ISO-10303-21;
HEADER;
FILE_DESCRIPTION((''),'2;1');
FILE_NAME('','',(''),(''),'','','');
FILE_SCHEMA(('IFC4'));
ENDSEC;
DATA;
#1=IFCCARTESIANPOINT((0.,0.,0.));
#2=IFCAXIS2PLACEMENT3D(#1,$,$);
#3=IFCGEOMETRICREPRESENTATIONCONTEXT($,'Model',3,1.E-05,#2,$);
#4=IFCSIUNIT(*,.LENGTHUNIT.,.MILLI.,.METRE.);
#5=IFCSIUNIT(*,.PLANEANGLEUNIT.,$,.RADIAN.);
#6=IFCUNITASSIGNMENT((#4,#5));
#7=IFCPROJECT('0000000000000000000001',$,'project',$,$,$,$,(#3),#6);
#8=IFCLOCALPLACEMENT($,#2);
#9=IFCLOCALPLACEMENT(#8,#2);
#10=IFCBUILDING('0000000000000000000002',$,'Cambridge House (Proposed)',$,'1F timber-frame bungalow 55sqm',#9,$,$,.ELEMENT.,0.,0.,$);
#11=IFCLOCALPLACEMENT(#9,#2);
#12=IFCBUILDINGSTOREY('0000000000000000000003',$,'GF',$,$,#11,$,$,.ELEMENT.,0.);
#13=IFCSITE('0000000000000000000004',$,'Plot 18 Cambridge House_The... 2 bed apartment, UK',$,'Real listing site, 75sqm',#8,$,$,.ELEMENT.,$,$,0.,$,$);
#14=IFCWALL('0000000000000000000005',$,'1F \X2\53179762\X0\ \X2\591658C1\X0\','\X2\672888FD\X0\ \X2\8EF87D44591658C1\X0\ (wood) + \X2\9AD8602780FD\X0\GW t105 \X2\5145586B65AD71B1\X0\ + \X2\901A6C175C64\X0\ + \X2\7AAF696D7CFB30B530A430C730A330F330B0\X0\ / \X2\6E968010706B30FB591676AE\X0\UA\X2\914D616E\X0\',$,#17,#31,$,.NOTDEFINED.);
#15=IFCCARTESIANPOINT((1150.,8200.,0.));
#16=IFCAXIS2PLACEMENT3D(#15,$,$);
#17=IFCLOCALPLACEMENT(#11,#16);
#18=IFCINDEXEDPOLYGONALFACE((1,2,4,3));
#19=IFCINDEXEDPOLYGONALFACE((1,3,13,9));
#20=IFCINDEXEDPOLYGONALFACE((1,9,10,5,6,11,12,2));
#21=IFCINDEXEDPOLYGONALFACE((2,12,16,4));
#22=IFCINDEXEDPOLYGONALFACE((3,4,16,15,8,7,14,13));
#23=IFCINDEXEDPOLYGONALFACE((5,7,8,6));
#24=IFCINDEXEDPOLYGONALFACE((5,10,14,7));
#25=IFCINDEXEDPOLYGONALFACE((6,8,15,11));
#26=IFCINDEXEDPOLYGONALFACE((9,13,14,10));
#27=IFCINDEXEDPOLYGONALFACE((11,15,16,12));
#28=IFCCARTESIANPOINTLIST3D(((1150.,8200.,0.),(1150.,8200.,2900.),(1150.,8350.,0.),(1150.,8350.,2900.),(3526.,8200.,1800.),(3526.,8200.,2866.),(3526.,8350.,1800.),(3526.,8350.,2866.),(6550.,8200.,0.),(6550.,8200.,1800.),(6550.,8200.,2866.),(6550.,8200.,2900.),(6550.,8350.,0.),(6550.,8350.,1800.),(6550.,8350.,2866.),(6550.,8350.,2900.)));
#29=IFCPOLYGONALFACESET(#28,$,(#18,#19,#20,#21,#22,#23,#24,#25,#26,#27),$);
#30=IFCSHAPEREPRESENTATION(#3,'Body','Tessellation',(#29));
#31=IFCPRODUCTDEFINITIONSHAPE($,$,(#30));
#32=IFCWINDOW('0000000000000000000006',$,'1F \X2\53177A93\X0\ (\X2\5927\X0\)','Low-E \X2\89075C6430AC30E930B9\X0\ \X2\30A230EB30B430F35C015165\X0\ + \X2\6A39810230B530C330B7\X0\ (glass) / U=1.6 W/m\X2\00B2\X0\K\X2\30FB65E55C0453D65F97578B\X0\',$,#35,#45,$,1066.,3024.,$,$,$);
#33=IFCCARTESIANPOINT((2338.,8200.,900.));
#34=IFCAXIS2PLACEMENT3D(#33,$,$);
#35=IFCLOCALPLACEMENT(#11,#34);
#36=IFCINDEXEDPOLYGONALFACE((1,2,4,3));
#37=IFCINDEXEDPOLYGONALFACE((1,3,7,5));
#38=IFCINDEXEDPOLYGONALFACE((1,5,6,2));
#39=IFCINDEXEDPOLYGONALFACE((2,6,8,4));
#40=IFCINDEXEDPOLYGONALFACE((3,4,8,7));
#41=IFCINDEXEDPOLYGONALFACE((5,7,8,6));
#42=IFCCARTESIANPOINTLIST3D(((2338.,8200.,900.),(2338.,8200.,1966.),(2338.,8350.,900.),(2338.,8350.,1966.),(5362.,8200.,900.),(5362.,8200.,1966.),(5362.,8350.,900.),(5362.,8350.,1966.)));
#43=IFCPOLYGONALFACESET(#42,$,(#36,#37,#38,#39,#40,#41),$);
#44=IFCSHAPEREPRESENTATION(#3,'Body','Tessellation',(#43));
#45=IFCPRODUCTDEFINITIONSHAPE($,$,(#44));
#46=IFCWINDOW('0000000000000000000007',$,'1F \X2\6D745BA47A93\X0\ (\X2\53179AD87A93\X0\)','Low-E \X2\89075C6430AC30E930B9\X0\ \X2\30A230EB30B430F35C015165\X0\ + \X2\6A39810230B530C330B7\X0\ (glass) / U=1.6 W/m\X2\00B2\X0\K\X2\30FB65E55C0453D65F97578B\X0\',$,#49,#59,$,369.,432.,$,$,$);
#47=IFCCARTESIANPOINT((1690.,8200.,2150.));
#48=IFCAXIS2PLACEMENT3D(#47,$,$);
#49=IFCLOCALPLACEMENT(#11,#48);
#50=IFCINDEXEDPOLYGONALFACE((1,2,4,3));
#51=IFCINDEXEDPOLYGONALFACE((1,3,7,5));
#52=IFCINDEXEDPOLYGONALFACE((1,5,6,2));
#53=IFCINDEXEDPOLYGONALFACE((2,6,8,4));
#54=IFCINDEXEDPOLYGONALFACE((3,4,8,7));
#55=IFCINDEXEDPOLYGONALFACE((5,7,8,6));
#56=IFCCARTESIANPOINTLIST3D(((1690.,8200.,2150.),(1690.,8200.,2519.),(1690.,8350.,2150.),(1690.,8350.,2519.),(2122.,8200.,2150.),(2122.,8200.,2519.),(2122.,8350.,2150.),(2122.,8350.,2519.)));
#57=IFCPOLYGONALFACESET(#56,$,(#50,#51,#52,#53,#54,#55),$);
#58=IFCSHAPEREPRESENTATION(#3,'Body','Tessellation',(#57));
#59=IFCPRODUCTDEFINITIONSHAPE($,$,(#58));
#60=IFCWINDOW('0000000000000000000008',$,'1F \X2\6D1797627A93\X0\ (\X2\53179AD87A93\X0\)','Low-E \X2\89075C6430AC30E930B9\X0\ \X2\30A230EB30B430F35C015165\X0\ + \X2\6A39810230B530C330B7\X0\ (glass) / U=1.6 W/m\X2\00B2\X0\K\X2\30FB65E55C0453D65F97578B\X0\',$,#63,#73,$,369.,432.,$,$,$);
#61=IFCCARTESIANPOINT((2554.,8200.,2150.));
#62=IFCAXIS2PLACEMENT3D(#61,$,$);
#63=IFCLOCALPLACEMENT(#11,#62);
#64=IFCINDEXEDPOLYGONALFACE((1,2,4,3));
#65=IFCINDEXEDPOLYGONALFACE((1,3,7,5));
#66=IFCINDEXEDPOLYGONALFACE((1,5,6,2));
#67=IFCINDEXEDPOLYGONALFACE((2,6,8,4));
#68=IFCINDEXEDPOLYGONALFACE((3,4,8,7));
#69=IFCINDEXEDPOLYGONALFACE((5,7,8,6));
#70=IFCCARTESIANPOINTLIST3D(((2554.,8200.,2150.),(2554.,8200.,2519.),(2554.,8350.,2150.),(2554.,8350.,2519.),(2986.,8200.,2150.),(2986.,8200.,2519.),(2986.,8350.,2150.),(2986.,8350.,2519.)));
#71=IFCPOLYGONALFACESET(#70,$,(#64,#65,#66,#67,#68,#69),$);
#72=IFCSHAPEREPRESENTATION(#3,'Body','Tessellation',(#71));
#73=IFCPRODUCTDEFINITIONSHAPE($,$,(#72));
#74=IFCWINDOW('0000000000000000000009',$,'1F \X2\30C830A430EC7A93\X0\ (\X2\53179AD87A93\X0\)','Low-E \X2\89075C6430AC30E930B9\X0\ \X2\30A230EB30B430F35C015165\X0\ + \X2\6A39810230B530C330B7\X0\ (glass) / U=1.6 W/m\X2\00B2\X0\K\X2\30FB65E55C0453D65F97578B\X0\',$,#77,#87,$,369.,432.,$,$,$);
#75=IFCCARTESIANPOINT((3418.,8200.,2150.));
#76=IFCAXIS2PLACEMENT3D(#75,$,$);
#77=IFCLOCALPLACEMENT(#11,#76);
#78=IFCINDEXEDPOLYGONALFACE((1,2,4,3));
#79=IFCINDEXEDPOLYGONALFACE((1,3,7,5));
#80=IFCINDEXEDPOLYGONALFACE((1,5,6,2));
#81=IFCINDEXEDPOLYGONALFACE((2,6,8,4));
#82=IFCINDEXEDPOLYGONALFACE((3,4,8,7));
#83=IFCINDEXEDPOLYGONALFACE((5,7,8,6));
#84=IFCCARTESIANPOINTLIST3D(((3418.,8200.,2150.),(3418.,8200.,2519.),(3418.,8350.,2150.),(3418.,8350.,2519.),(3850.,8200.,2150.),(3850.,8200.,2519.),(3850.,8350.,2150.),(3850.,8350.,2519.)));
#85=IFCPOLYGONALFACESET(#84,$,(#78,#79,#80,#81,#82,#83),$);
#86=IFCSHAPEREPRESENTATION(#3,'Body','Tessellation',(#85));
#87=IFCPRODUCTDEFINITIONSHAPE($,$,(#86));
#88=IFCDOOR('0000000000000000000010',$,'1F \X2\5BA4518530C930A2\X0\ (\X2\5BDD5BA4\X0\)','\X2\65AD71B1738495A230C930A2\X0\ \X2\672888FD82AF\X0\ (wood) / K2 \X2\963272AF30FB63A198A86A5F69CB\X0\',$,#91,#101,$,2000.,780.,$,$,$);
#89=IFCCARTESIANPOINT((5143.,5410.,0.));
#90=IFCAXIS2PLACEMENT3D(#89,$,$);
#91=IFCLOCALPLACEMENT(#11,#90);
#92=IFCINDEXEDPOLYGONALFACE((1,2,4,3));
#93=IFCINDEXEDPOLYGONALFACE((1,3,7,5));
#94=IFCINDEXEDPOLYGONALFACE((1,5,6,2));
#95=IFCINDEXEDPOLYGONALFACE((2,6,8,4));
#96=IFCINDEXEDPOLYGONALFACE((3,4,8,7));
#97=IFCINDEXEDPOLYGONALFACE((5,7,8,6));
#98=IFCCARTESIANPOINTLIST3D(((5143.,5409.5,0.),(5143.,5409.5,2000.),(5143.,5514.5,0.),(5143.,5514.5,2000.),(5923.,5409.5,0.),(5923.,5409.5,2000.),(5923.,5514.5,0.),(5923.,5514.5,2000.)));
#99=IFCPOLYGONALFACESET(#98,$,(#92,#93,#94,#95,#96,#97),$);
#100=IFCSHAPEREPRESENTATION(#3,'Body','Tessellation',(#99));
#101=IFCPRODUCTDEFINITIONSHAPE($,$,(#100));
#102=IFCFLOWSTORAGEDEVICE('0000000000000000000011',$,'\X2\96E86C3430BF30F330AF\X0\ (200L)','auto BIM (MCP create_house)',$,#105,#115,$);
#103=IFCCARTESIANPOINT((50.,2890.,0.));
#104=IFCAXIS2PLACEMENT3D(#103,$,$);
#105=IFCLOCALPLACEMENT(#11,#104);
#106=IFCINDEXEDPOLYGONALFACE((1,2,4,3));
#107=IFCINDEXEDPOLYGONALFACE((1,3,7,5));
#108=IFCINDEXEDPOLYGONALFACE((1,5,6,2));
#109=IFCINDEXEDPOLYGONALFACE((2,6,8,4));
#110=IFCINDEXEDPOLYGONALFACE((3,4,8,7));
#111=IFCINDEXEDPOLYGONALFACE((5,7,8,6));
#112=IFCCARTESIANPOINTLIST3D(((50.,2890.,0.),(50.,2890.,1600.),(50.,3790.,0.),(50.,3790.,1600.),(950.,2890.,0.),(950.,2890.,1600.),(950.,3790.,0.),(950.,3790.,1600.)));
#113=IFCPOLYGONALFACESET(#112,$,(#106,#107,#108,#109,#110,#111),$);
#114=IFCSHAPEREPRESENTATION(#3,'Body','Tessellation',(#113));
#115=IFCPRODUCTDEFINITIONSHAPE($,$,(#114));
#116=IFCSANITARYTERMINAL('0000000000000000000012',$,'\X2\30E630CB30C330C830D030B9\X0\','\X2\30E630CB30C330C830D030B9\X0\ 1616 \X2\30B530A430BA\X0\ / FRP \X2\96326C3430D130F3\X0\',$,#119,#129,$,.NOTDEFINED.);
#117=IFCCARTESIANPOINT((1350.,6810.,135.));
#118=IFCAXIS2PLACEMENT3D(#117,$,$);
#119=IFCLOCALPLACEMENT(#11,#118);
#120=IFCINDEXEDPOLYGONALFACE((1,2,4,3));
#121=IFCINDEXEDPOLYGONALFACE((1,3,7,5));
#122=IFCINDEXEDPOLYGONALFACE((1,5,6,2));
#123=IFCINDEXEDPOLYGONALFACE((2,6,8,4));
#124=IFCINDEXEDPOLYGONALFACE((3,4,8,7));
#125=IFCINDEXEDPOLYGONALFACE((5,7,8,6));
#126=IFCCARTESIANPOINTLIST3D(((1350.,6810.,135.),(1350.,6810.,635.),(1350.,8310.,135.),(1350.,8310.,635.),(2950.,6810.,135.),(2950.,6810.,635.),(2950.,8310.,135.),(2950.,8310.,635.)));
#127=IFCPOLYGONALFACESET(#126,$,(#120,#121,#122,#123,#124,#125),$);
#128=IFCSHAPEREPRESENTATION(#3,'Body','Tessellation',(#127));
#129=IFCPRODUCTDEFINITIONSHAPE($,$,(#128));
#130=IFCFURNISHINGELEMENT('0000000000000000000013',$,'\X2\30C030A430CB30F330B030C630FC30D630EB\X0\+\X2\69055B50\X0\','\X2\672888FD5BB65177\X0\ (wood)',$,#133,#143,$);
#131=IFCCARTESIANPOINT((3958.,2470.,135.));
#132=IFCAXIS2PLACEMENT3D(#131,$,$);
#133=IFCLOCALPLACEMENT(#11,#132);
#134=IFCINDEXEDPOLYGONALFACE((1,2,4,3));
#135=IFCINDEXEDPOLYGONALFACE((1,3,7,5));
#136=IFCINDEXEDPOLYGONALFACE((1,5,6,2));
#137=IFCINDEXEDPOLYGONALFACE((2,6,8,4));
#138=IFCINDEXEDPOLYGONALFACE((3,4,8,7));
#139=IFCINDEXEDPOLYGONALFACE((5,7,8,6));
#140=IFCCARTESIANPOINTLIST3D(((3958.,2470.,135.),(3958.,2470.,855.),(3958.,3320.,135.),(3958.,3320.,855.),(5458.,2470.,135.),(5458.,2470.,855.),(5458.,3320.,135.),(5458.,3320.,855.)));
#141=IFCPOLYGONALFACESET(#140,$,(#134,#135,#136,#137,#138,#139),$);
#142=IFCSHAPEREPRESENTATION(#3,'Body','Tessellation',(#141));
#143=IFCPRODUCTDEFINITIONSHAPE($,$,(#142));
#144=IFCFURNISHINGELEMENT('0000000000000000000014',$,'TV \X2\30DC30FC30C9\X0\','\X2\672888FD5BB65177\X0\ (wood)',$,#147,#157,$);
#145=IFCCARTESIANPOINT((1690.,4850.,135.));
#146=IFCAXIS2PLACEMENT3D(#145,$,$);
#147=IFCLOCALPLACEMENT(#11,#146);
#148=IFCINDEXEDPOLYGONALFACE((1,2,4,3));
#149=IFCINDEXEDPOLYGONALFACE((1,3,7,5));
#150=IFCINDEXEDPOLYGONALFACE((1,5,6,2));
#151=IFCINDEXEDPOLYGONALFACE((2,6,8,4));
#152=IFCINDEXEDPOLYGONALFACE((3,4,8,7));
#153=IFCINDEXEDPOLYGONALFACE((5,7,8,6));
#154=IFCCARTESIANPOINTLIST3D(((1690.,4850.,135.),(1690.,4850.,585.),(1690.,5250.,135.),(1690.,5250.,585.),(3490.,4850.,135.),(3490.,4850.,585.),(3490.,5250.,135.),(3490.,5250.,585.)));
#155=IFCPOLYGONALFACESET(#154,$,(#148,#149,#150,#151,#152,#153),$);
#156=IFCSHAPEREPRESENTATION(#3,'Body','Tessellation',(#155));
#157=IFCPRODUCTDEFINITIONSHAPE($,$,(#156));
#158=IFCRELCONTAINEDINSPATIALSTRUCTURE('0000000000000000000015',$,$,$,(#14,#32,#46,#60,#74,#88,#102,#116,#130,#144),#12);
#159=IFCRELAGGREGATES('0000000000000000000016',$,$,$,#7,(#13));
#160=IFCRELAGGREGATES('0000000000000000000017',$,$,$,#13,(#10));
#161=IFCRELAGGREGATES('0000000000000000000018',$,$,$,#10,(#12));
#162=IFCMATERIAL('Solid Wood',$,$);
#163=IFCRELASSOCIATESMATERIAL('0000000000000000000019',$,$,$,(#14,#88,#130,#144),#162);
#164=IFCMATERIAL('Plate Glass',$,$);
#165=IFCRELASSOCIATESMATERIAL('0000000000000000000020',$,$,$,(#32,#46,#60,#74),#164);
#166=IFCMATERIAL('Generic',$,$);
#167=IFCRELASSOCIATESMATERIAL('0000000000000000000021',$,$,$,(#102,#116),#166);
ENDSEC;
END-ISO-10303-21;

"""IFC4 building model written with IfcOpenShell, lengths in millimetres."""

from ifc_helpers import new_model, si_unit, frame, frame_2d, origin, place, context, project, spatial, rectangle, extrude, material, element, fill, save


model = new_model("IFC4")

# Units and contexts
model_context = context("Model", 3, precision=1e-05, world=origin())
ifc_project = project(units=[si_unit("LENGTHUNIT", "METRE", prefix="MILLI"), si_unit("PLANEANGLEUNIT", "RADIAN")], contexts=[model_context])

# Site, building, storey
site_placement = place(None, origin())
site = spatial("IfcSite", under=ifc_project, at=site_placement, Name="Plot 18 Cambridge House_The... 2 bed apartment, UK", ObjectType="Real listing site, 75sqm", CompositionType="ELEMENT", RefElevation=0.0)
building_placement = place(site_placement, origin())
building = spatial("IfcBuilding", under=site, at=building_placement, Name="Cambridge House (Proposed)", ObjectType="1F timber-frame bungalow 55sqm", CompositionType="ELEMENT", ElevationOfRefHeight=0.0, ElevationOfTerrain=0.0)
storey_placement = place(building_placement, origin())
storey = spatial("IfcBuildingStorey", under=building, at=storey_placement, Name="GF", CompositionType="ELEMENT", Elevation=0.0)

# Wall, openings, windows
ifc_material_1 = material(Name="Solid Wood")
wall_1_placement = place(storey_placement, frame((1150.0, 8200.0, 0.0)))
wall_1 = element("IfcWall", 1, at=wall_1_placement, inside=storey, material=ifc_material_1, Name="1F 北面 外壁", Description="木製 軸組外壁 (wood) + 高性能GW t105 充填断熱 + 通気層 + 窯業系サイディング / 準耐火・外皮UA配慮", PredefinedType="NOTDEFINED", context=model_context, shape_type="SweptSolid", body=[
    extrude(rectangle(XDim=5400.0, YDim=150.0, at=frame_2d((2700.0, 75.0))), frame((1150.0, 8200.0, 0.0)), (0.0, 0.0, 1.0), 2900.0),
])
opening_1_placement = place(storey_placement, frame((2338.0, 8200.0, 900.0)))
opening_1 = element("IfcOpeningElement", 2, at=opening_1_placement, cuts=wall_1, PredefinedType="NOTDEFINED", context=model_context, shape_type="SweptSolid", body=[
    extrude(rectangle(XDim=3024.0, YDim=150.0, at=frame_2d((1512.0, 75.0))), frame((2338.0, 8200.0, 900.0)), (0.0, 0.0, 1.0), 1066.0),
])
opening_2_placement = place(storey_placement, frame((1690.0, 8200.0, 2150.0)))
opening_2 = element("IfcOpeningElement", 3, at=opening_2_placement, cuts=wall_1, PredefinedType="NOTDEFINED", context=model_context, shape_type="SweptSolid", body=[
    extrude(rectangle(XDim=432.0, YDim=150.0, at=frame_2d((216.0, 75.0))), frame((1690.0, 8200.0, 2150.0)), (0.0, 0.0, 1.0), 369.0),
])
opening_3_placement = place(storey_placement, frame((2554.0, 8200.0, 2150.0)))
opening_3 = element("IfcOpeningElement", 4, at=opening_3_placement, cuts=wall_1, PredefinedType="NOTDEFINED", context=model_context, shape_type="SweptSolid", body=[
    extrude(rectangle(XDim=432.0, YDim=150.0, at=frame_2d((216.0, 75.0))), frame((2554.0, 8200.0, 2150.0)), (0.0, 0.0, 1.0), 369.0),
])
opening_4_placement = place(storey_placement, frame((3418.0, 8200.0, 2150.0)))
opening_4 = element("IfcOpeningElement", 5, at=opening_4_placement, cuts=wall_1, PredefinedType="NOTDEFINED", context=model_context, shape_type="SweptSolid", body=[
    extrude(rectangle(XDim=432.0, YDim=150.0, at=frame_2d((216.0, 75.0))), frame((3418.0, 8200.0, 2150.0)), (0.0, 0.0, 1.0), 369.0),
])
ifc_material_2 = material(Name="Plate Glass")
window_1_placement = place(storey_placement, frame((2338.0, 8200.0, 900.0)))
window_1 = element("IfcWindow", 6, at=window_1_placement, inside=storey, material=ifc_material_2, Name="1F 北窓 (大)", Description="Low-E 複層ガラス アルゴン封入 + 樹脂サッシ (glass) / U=1.6 W/m²K・日射取得型", OverallHeight=1066.0, OverallWidth=3024.0, context=model_context, shape_type="SweptSolid", body=[
    extrude(rectangle(XDim=3024.0, YDim=150.0, at=frame_2d((1512.0, 75.0))), frame((2338.0, 8200.0, 900.0)), (0.0, 0.0, 1.0), 1066.0),
])
fill(opening_1, window_1)
window_2_placement = place(storey_placement, frame((1690.0, 8200.0, 2150.0)))
window_2 = element("IfcWindow", 7, at=window_2_placement, inside=storey, material=ifc_material_2, Name="1F 浴室窓 (北高窓)", Description="Low-E 複層ガラス アルゴン封入 + 樹脂サッシ (glass) / U=1.6 W/m²K・日射取得型", OverallHeight=369.0, OverallWidth=432.0, context=model_context, shape_type="SweptSolid", body=[
    extrude(rectangle(XDim=432.0, YDim=150.0, at=frame_2d((216.0, 75.0))), frame((1690.0, 8200.0, 2150.0)), (0.0, 0.0, 1.0), 369.0),
])
fill(opening_2, window_2)
window_3_placement = place(storey_placement, frame((2554.0, 8200.0, 2150.0)))
window_3 = element("IfcWindow", 8, at=window_3_placement, inside=storey, material=ifc_material_2, Name="1F 洗面窓 (北高窓)", Description="Low-E 複層ガラス アルゴン封入 + 樹脂サッシ (glass) / U=1.6 W/m²K・日射取得型", OverallHeight=369.0, OverallWidth=432.0, context=model_context, shape_type="SweptSolid", body=[
    extrude(rectangle(XDim=432.0, YDim=150.0, at=frame_2d((216.0, 75.0))), frame((2554.0, 8200.0, 2150.0)), (0.0, 0.0, 1.0), 369.0),
])
fill(opening_3, window_3)
window_4_placement = place(storey_placement, frame((3418.0, 8200.0, 2150.0)))
window_4 = element("IfcWindow", 9, at=window_4_placement, inside=storey, material=ifc_material_2, Name="1F トイレ窓 (北高窓)", Description="Low-E 複層ガラス アルゴン封入 + 樹脂サッシ (glass) / U=1.6 W/m²K・日射取得型", OverallHeight=369.0, OverallWidth=432.0, context=model_context, shape_type="SweptSolid", body=[
    extrude(rectangle(XDim=432.0, YDim=150.0, at=frame_2d((216.0, 75.0))), frame((3418.0, 8200.0, 2150.0)), (0.0, 0.0, 1.0), 369.0),
])
fill(opening_4, window_4)

# Door
door_1_placement = place(storey_placement, frame((5143.0, 5410.0, 0.0)))
element("IfcDoor", 10, at=door_1_placement, inside=storey, material=ifc_material_1, Name="1F 室内ドア (寝室)", Description="断熱玄関ドア 木製芯 (wood) / K2 防犯・採風機構", OverallHeight=2000.0, OverallWidth=780.0, context=model_context, shape_type="SweptSolid", body=[
    extrude(rectangle(XDim=780.0, YDim=105.0, at=frame_2d((390.0, 52.0))), frame((5143.0, 5410.0, 0.0)), (0.0, 0.0, 1.0), 2000.0),
])

# Flow storage device
ifc_material_3 = material(Name="Generic")
flow_storage_device_placement = place(storey_placement, frame((50.0, 2890.0, 0.0)))
element("IfcFlowStorageDevice", 11, at=flow_storage_device_placement, inside=storey, material=ifc_material_3, Name="雨水タンク (200L)", Description="auto BIM (MCP create_house)", context=model_context, shape_type="SweptSolid", body=[
    extrude(rectangle(XDim=900.0, YDim=900.0, at=frame_2d((450.0, 450.0))), frame((50.0, 2890.0, 0.0)), (0.0, 0.0, 1.0), 1600.0),
])

# Sanitary terminal
sanitary_terminal_placement = place(storey_placement, frame((1350.0, 6810.0, 135.0)))
element("IfcSanitaryTerminal", 12, at=sanitary_terminal_placement, inside=storey, material=ifc_material_3, Name="ユニットバス", Description="ユニットバス 1616 サイズ / FRP 防水パン", PredefinedType="NOTDEFINED", context=model_context, shape_type="SweptSolid", body=[
    extrude(rectangle(XDim=1600.0, YDim=1500.0, at=frame_2d((800.0, 750.0))), frame((1350.0, 6810.0, 135.0)), (0.0, 0.0, 1.0), 500.0),
])

# Furnishing elements
furnishing_1_placement = place(storey_placement, frame((3958.0, 2470.0, 135.0)))
element("IfcFurnishingElement", 13, at=furnishing_1_placement, inside=storey, material=ifc_material_1, Name="ダイニングテーブル+椅子", Description="木製家具 (wood)", context=model_context, shape_type="SweptSolid", body=[
    extrude(rectangle(XDim=1500.0, YDim=850.0, at=frame_2d((750.0, 425.0))), frame((3958.0, 2470.0, 135.0)), (0.0, 0.0, 1.0), 720.0),
])
furnishing_2_placement = place(storey_placement, frame((1690.0, 4850.0, 135.0)))
element("IfcFurnishingElement", 14, at=furnishing_2_placement, inside=storey, material=ifc_material_1, Name="TV ボード", Description="木製家具 (wood)", context=model_context, shape_type="SweptSolid", body=[
    extrude(rectangle(XDim=1800.0, YDim=400.0, at=frame_2d((900.0, 200.0))), frame((1690.0, 4850.0, 135.0)), (0.0, 0.0, 1.0), 450.0),
])

save(model, "model.ifc")
